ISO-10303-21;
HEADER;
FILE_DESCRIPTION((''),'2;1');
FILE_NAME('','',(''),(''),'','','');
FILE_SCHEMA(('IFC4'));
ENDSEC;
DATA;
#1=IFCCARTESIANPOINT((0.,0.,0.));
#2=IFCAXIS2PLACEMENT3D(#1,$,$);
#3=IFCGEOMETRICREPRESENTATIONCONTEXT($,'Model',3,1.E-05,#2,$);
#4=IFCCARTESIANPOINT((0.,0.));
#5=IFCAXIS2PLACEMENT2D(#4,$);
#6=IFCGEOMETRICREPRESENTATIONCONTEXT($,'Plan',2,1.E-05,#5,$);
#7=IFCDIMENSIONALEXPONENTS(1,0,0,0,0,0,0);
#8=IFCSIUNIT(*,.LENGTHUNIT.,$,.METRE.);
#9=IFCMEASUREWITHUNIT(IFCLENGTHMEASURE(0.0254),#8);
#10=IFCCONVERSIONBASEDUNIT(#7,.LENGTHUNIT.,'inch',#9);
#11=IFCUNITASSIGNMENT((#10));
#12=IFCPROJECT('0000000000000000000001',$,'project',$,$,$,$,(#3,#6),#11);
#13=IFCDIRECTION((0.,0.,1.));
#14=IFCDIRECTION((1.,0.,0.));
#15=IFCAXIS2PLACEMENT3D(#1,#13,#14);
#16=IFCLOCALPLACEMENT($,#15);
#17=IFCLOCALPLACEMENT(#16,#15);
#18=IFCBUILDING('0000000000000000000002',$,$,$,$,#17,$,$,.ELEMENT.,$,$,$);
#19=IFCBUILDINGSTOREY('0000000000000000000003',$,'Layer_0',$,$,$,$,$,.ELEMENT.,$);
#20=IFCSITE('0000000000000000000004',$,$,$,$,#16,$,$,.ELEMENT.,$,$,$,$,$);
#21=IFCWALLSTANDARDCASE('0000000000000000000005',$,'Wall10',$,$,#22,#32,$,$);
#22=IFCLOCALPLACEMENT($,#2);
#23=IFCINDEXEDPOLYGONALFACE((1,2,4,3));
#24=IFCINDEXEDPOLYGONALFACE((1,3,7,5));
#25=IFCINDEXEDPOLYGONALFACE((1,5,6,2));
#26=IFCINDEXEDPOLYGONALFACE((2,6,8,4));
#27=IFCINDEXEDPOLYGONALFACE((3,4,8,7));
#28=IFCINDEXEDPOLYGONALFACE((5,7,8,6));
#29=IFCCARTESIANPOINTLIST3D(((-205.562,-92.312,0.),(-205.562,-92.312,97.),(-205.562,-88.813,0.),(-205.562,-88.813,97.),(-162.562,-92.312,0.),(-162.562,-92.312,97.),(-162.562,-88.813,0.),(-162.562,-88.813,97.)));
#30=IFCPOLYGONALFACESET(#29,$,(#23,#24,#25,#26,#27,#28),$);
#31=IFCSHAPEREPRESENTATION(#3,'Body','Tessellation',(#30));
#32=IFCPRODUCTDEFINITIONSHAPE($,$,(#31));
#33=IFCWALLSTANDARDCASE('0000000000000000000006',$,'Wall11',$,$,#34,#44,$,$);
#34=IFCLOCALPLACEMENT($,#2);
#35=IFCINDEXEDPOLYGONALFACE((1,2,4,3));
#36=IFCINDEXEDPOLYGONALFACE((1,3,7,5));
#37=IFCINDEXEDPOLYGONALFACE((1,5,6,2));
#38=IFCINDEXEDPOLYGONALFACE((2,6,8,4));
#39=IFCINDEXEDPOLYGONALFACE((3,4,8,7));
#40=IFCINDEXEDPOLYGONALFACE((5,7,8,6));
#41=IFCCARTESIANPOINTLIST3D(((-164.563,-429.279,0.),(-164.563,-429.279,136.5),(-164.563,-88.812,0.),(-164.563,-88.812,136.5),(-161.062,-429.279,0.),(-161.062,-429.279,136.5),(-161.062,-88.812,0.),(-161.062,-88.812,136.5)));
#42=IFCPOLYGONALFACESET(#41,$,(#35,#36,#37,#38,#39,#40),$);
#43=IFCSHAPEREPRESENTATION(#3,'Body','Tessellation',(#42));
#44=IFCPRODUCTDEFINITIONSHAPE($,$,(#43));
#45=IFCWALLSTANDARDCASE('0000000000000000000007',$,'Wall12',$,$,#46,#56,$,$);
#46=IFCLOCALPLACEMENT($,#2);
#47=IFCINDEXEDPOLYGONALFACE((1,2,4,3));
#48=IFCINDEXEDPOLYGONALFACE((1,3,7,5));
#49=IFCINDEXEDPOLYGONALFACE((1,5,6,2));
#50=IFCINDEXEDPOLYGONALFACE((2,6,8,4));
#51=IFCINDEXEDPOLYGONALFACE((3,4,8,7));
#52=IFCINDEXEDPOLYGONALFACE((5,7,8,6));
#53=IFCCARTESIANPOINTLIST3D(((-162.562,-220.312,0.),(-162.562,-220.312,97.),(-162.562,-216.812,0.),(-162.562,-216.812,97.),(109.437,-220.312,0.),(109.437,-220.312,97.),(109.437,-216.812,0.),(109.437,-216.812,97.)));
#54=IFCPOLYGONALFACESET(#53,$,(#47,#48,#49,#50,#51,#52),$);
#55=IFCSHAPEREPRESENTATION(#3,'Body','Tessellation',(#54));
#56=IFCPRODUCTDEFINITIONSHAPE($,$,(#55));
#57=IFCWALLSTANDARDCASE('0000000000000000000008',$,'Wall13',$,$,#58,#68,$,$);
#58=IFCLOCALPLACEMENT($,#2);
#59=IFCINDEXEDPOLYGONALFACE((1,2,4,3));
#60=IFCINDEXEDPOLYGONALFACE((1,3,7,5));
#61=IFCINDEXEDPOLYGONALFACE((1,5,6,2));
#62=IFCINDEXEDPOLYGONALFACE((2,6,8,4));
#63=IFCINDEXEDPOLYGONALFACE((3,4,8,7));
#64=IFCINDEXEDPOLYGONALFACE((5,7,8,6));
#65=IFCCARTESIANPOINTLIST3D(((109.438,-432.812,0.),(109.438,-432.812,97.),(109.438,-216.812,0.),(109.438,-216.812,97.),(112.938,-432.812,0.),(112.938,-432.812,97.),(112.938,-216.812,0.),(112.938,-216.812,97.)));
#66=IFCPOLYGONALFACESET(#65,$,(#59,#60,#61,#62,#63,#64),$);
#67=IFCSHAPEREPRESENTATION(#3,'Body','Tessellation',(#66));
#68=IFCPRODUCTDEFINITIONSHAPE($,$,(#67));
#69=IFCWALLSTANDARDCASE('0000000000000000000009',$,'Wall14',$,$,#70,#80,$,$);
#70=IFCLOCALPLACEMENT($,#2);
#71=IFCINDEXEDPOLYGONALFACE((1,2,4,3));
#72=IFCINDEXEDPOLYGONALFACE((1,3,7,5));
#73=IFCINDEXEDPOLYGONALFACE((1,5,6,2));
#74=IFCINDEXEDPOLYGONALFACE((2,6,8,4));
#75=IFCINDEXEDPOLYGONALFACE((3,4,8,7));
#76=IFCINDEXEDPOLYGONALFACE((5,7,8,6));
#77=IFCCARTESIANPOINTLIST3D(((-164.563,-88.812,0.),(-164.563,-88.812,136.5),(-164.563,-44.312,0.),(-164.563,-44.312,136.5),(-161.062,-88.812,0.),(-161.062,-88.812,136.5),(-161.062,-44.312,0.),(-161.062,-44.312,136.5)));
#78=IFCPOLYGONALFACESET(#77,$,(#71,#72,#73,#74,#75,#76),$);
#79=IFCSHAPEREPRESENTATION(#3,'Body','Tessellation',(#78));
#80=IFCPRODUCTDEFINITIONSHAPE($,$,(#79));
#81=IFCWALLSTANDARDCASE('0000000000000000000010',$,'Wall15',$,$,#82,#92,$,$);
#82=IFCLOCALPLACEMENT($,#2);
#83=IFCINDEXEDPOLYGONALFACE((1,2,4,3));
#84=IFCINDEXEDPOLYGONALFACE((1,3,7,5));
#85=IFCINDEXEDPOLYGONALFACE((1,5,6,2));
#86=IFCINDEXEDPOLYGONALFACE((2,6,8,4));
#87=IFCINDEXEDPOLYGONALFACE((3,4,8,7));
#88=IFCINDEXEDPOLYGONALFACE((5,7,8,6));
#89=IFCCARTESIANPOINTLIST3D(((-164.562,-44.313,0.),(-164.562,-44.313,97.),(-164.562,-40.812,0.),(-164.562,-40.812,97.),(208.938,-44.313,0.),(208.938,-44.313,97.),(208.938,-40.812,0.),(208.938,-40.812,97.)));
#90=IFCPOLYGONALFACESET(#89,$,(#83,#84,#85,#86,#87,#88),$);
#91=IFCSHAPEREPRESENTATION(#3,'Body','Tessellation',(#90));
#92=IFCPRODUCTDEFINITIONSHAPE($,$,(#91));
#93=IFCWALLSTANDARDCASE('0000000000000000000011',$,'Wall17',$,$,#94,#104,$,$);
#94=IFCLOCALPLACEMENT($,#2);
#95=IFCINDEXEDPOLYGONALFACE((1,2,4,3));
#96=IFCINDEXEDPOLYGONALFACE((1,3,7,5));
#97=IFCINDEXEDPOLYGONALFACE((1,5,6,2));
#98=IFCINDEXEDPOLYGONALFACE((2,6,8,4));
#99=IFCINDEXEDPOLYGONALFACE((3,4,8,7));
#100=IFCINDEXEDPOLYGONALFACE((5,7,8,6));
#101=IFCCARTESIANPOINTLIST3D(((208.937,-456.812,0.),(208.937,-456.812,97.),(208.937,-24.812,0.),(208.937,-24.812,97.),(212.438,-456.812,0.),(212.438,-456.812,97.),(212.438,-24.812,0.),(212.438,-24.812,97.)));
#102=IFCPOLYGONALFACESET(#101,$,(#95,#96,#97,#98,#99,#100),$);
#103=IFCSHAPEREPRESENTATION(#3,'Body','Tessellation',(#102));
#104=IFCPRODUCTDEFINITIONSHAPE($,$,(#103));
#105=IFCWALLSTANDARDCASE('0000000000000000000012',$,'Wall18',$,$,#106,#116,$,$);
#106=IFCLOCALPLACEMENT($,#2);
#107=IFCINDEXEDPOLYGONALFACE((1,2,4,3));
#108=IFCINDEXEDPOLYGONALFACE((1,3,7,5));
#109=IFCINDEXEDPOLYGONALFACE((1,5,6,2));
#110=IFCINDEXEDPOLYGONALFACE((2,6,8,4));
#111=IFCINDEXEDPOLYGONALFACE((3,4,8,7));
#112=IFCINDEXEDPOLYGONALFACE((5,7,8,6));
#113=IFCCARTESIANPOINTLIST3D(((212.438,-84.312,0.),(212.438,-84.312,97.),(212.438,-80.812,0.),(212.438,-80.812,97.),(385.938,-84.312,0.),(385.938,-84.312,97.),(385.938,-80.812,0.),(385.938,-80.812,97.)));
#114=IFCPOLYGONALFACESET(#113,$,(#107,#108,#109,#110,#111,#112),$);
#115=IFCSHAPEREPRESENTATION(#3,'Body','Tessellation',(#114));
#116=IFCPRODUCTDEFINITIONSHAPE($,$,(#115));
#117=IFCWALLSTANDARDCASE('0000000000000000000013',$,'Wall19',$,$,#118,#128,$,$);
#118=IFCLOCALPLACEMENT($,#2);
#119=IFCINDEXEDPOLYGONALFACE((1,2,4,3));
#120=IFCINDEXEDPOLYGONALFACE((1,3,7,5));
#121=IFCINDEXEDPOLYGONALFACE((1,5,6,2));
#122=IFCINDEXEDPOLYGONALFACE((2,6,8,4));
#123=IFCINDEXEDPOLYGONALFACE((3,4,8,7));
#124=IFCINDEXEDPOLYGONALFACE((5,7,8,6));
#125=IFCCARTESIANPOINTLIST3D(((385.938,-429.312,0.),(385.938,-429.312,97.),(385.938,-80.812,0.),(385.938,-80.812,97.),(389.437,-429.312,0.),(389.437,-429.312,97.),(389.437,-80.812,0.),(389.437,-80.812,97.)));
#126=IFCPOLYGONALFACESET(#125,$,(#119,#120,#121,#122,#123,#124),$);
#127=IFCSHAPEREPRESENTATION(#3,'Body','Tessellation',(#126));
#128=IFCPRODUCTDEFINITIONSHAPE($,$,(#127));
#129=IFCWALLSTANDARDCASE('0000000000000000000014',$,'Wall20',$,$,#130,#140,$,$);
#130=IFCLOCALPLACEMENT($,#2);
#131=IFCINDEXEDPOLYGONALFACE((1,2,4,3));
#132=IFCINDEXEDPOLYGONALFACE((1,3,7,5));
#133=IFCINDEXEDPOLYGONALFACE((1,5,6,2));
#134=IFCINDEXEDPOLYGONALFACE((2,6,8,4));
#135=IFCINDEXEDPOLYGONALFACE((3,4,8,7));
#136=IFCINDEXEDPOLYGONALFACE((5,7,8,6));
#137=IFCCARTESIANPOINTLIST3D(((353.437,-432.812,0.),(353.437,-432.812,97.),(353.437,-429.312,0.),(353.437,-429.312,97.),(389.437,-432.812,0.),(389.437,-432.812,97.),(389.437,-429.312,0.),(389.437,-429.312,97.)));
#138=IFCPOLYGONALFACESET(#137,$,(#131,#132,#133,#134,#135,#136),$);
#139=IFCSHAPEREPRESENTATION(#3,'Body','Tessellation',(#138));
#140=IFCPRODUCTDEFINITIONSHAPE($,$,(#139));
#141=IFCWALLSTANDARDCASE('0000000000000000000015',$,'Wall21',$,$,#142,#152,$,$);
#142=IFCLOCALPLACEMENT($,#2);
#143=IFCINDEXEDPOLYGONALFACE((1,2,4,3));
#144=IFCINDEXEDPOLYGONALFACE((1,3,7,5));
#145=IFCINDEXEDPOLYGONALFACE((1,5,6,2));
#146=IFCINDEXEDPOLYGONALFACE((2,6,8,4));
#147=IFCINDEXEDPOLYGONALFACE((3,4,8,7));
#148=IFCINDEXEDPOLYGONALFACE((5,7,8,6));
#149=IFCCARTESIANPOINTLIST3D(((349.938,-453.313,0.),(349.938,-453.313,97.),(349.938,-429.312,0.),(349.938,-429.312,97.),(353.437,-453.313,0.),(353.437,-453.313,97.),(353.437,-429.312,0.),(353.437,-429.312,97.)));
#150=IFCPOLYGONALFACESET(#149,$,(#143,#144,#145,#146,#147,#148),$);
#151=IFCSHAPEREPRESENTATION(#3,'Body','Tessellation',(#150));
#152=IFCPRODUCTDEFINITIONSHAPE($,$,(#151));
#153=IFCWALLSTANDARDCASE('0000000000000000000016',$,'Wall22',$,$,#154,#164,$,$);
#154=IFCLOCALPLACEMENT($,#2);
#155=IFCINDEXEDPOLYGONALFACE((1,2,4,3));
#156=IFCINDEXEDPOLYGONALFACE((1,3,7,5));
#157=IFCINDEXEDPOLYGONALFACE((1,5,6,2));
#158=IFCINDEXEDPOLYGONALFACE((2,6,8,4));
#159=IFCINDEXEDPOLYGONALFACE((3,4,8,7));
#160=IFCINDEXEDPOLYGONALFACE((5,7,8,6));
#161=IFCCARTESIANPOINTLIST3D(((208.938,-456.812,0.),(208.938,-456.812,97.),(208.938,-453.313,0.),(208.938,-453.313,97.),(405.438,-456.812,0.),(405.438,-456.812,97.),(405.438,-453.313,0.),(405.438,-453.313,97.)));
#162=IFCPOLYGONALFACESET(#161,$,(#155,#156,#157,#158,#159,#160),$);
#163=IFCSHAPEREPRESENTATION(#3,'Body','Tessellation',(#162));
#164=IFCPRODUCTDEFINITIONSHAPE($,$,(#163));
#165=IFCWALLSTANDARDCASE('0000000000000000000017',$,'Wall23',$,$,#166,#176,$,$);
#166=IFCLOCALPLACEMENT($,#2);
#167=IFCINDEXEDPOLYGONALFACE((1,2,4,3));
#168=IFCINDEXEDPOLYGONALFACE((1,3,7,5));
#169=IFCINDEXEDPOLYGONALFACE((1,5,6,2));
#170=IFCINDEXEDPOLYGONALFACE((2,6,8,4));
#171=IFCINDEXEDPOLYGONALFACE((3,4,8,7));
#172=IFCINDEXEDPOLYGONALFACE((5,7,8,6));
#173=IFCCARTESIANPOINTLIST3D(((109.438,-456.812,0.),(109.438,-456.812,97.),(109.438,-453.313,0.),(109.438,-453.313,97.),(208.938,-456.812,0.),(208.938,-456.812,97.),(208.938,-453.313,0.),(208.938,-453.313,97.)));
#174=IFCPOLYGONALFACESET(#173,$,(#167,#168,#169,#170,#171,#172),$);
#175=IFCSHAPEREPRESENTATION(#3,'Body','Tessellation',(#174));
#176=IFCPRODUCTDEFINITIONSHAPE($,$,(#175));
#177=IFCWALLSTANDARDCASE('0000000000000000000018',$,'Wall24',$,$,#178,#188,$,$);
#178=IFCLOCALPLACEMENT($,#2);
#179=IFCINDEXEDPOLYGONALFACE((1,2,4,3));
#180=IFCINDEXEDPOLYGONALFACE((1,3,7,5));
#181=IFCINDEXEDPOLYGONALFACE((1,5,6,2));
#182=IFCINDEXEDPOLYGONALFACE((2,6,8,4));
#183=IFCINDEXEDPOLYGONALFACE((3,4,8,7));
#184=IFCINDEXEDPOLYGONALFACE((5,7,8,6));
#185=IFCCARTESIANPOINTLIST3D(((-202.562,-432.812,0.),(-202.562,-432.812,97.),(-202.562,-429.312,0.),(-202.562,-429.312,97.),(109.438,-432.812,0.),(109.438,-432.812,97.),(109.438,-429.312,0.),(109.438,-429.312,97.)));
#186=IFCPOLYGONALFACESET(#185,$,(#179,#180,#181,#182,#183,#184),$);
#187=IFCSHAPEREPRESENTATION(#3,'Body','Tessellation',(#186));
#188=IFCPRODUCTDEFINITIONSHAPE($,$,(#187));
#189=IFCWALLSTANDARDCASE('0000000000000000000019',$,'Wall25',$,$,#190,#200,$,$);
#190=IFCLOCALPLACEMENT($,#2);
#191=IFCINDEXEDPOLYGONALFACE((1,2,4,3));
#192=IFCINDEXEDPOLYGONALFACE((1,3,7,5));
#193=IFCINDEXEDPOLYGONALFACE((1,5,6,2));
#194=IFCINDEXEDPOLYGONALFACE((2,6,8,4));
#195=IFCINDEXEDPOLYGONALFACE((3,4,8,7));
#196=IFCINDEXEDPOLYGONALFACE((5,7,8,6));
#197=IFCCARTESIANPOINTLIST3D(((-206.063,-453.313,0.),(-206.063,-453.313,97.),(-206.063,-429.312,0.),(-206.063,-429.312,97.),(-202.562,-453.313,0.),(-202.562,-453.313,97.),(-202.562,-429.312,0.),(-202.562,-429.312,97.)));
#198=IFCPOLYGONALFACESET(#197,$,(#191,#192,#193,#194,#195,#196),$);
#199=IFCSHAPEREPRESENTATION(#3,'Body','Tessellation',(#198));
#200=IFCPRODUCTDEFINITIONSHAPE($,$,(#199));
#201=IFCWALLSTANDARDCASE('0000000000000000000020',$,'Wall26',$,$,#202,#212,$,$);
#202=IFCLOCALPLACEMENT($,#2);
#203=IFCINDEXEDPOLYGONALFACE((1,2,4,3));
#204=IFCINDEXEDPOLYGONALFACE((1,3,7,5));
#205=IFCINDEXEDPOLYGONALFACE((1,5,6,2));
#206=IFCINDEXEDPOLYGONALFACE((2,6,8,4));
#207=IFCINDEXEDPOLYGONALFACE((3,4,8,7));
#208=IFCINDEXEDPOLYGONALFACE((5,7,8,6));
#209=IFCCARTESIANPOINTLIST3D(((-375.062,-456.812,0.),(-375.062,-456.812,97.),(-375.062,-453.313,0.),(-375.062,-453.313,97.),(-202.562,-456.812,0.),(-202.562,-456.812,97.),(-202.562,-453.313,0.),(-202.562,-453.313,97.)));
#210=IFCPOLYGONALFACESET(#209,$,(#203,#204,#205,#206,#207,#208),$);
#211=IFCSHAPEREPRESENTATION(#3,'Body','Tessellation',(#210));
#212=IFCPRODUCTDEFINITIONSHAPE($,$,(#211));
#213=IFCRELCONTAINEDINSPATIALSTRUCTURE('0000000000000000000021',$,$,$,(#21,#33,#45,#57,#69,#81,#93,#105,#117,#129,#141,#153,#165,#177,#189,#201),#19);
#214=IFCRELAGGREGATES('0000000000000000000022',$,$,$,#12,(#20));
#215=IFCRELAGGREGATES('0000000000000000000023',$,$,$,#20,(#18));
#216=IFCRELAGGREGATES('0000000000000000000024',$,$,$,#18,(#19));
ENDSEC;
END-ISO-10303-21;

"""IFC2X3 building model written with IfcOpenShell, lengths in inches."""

from ifc_helpers import new_model, entity, si_unit, converted_unit, frame, origin, origin_with_axes, origin_2d, place, context, project, spatial, polyline, outline, extrude, element, save


model = new_model("IFC2X3")

# Units and contexts
model_context = context("Model", 3, precision=1e-05, world=origin())
plan_context = context("Plan", 2, precision=1e-05, world=origin_2d())
ifc_project = project(units=[converted_unit("LENGTHUNIT", "inch", entity("IfcLengthMeasure", 0.0254), si_unit("LENGTHUNIT", "METRE"), dimensions=[1, 0, 0, 0, 0, 0, 0])], contexts=[model_context, plan_context])

# Site, building, storey
site_placement = place(None, origin_with_axes())
site = spatial("IfcSite", under=ifc_project, at=site_placement, CompositionType="ELEMENT")
building_placement = place(site_placement, origin_with_axes())
building = spatial("IfcBuilding", under=site, at=building_placement, CompositionType="ELEMENT")
storey = spatial("IfcBuildingStorey", under=building, Name="Layer_0", CompositionType="ELEMENT")

# Shared definitions
placement = place(building_placement, origin_with_axes())

# Walls
wall_1_placement = place(placement, frame((-205.562, -90.562, 0.0), z_axis=(0.0, 0.0, 1.0), x_axis=(1.0, 0.0, 0.0)))
element("IfcWallStandardCase", 1, at=wall_1_placement, inside=storey, Name="Wall10", context=model_context, shape_type="SweptSolid", body=[
    extrude(outline(polyline([(0.0, -1.75), (0.0, 1.75), (43.0, 1.75), (43.0, -1.75), (0.0, -1.75)])), origin(), (0.0, 0.0, 1.0), 97.0),
])
wall_2_placement = place(placement, frame((-162.812, -429.279, 0.0), z_axis=(0.0, 0.0, 1.0), x_axis=(0.0, 1.0, 0.0)))
element("IfcWallStandardCase", 2, at=wall_2_placement, inside=storey, Name="Wall11", context=model_context, shape_type="SweptSolid", body=[
    extrude(outline(polyline([(0.0, -1.75), (0.0, 1.75), (340.466, 1.75), (340.466, -1.75), (0.0, -1.75)])), origin(), (0.0, 0.0, 1.0), 136.5),
])
wall_3_placement = place(placement, frame((-162.562, -218.562, 0.0), z_axis=(0.0, 0.0, 1.0), x_axis=(1.0, 0.0, 0.0)))
element("IfcWallStandardCase", 3, at=wall_3_placement, inside=storey, Name="Wall12", context=model_context, shape_type="SweptSolid", body=[
    extrude(outline(polyline([(0.0, -1.75), (0.0, 1.75), (272.0, 1.75), (272.0, -1.75), (0.0, -1.75)])), origin(), (0.0, 0.0, 1.0), 97.0),
])
wall_4_placement = place(placement, frame((111.188, -216.812, 0.0), z_axis=(0.0, 0.0, 1.0), x_axis=(0.0, -1.0, 0.0)))
element("IfcWallStandardCase", 4, at=wall_4_placement, inside=storey, Name="Wall13", context=model_context, shape_type="SweptSolid", body=[
    extrude(outline(polyline([(0.0, -1.75), (0.0, 1.75), (216.0, 1.75), (216.0, -1.75), (0.0, -1.75)])), origin(), (0.0, 0.0, 1.0), 97.0),
])
wall_5_placement = place(placement, frame((-162.812, -88.812, 0.0), z_axis=(0.0, 0.0, 1.0), x_axis=(0.0, 1.0, 0.0)))
element("IfcWallStandardCase", 5, at=wall_5_placement, inside=storey, Name="Wall14", context=model_context, shape_type="SweptSolid", body=[
    extrude(outline(polyline([(0.0, -1.75), (0.0, 1.75), (44.5, 1.75), (44.5, -1.75), (0.0, -1.75)])), origin(), (0.0, 0.0, 1.0), 136.5),
])
wall_6_placement = place(placement, frame((-164.562, -42.562, 0.0), z_axis=(0.0, 0.0, 1.0), x_axis=(1.0, 0.0, 0.0)))
element("IfcWallStandardCase", 6, at=wall_6_placement, inside=storey, Name="Wall15", context=model_context, shape_type="SweptSolid", body=[
    extrude(outline(polyline([(0.0, -1.75), (0.0, 1.75), (373.5, 1.75), (373.5, -1.75), (0.0, -1.75)])), origin(), (0.0, 0.0, 1.0), 97.0),
])
wall_7_placement = place(placement, frame((210.688, -24.812, 0.0), z_axis=(0.0, 0.0, 1.0), x_axis=(0.0, -1.0, 0.0)))
element("IfcWallStandardCase", 7, at=wall_7_placement, inside=storey, Name="Wall17", context=model_context, shape_type="SweptSolid", body=[
    extrude(outline(polyline([(0.0, -1.75), (0.0, 1.75), (432.0, 1.75), (432.0, -1.75), (0.0, -1.75)])), origin(), (0.0, 0.0, 1.0), 97.0),
])
wall_8_placement = place(placement, frame((212.438, -82.562, 0.0), z_axis=(0.0, 0.0, 1.0), x_axis=(1.0, 0.0, 0.0)))
element("IfcWallStandardCase", 8, at=wall_8_placement, inside=storey, Name="Wall18", context=model_context, shape_type="SweptSolid", body=[
    extrude(outline(polyline([(0.0, -1.75), (0.0, 1.75), (173.5, 1.75), (173.5, -1.75), (0.0, -1.75)])), origin(), (0.0, 0.0, 1.0), 97.0),
])
wall_9_placement = place(placement, frame((387.688, -80.812, 0.0), z_axis=(0.0, 0.0, 1.0), x_axis=(0.0, -1.0, 0.0)))
element("IfcWallStandardCase", 9, at=wall_9_placement, inside=storey, Name="Wall19", context=model_context, shape_type="SweptSolid", body=[
    extrude(outline(polyline([(0.0, -1.75), (0.0, 1.75), (348.5, 1.75), (348.5, -1.75), (0.0, -1.75)])), origin(), (0.0, 0.0, 1.0), 97.0),
])
wall_10_placement = place(placement, frame((389.438, -431.062, 0.0), z_axis=(0.0, 0.0, 1.0), x_axis=(-1.0, 0.0, 0.0)))
element("IfcWallStandardCase", 10, at=wall_10_placement, inside=storey, Name="Wall20", context=model_context, shape_type="SweptSolid", body=[
    extrude(outline(polyline([(0.0, -1.75), (0.0, 1.75), (36.0, 1.75), (36.0, -1.75), (0.0, -1.75)])), origin(), (0.0, 0.0, 1.0), 97.0),
])
wall_11_placement = place(placement, frame((351.688, -429.312, 0.0), z_axis=(0.0, 0.0, 1.0), x_axis=(0.0, -1.0, 0.0)))
element("IfcWallStandardCase", 11, at=wall_11_placement, inside=storey, Name="Wall21", context=model_context, shape_type="SweptSolid", body=[
    extrude(outline(polyline([(0.0, -1.75), (0.0, 1.75), (24.0, 1.75), (24.0, -1.75), (0.0, -1.75)])), origin(), (0.0, 0.0, 1.0), 97.0),
])
wall_12_placement = place(placement, frame((405.438, -455.062, 0.0), z_axis=(0.0, 0.0, 1.0), x_axis=(-1.0, 0.0, 0.0)))
element("IfcWallStandardCase", 12, at=wall_12_placement, inside=storey, Name="Wall22", context=model_context, shape_type="SweptSolid", body=[
    extrude(outline(polyline([(0.0, -1.75), (0.0, 1.75), (196.5, 1.75), (196.5, -1.75), (0.0, -1.75)])), origin(), (0.0, 0.0, 1.0), 97.0),
])
wall_13_placement = place(placement, frame((208.938, -455.062, 0.0), z_axis=(0.0, 0.0, 1.0), x_axis=(-1.0, 0.0, 0.0)))
element("IfcWallStandardCase", 13, at=wall_13_placement, inside=storey, Name="Wall23", context=model_context, shape_type="SweptSolid", body=[
    extrude(outline(polyline([(0.0, -1.75), (0.0, 1.75), (99.5, 1.75), (99.5, -1.75), (0.0, -1.75)])), origin(), (0.0, 0.0, 1.0), 97.0),
])
wall_14_placement = place(placement, frame((109.438, -431.062, 0.0), z_axis=(0.0, 0.0, 1.0), x_axis=(-1.0, 0.0, 0.0)))
element("IfcWallStandardCase", 14, at=wall_14_placement, inside=storey, Name="Wall24", context=model_context, shape_type="SweptSolid", body=[
    extrude(outline(polyline([(0.0, -1.75), (0.0, 1.75), (312.0, 1.75), (312.0, -1.75), (0.0, -1.75)])), origin(), (0.0, 0.0, 1.0), 97.0),
])
wall_15_placement = place(placement, frame((-204.312, -429.312, 0.0), z_axis=(0.0, 0.0, 1.0), x_axis=(0.0, -1.0, 0.0)))
element("IfcWallStandardCase", 15, at=wall_15_placement, inside=storey, Name="Wall25", context=model_context, shape_type="SweptSolid", body=[
    extrude(outline(polyline([(0.0, -1.75), (0.0, 1.75), (24.0, 1.75), (24.0, -1.75), (0.0, -1.75)])), origin(), (0.0, 0.0, 1.0), 97.0),
])
wall_16_placement = place(placement, frame((-202.562, -455.062, 0.0), z_axis=(0.0, 0.0, 1.0), x_axis=(-1.0, 0.0, 0.0)))
element("IfcWallStandardCase", 16, at=wall_16_placement, inside=storey, Name="Wall26", context=model_context, shape_type="SweptSolid", body=[
    extrude(outline(polyline([(0.0, -1.75), (0.0, 1.75), (172.5, 1.75), (172.5, -1.75), (0.0, -1.75)])), origin(), (0.0, 0.0, 1.0), 97.0),
])

save(model, "model.ifc")
